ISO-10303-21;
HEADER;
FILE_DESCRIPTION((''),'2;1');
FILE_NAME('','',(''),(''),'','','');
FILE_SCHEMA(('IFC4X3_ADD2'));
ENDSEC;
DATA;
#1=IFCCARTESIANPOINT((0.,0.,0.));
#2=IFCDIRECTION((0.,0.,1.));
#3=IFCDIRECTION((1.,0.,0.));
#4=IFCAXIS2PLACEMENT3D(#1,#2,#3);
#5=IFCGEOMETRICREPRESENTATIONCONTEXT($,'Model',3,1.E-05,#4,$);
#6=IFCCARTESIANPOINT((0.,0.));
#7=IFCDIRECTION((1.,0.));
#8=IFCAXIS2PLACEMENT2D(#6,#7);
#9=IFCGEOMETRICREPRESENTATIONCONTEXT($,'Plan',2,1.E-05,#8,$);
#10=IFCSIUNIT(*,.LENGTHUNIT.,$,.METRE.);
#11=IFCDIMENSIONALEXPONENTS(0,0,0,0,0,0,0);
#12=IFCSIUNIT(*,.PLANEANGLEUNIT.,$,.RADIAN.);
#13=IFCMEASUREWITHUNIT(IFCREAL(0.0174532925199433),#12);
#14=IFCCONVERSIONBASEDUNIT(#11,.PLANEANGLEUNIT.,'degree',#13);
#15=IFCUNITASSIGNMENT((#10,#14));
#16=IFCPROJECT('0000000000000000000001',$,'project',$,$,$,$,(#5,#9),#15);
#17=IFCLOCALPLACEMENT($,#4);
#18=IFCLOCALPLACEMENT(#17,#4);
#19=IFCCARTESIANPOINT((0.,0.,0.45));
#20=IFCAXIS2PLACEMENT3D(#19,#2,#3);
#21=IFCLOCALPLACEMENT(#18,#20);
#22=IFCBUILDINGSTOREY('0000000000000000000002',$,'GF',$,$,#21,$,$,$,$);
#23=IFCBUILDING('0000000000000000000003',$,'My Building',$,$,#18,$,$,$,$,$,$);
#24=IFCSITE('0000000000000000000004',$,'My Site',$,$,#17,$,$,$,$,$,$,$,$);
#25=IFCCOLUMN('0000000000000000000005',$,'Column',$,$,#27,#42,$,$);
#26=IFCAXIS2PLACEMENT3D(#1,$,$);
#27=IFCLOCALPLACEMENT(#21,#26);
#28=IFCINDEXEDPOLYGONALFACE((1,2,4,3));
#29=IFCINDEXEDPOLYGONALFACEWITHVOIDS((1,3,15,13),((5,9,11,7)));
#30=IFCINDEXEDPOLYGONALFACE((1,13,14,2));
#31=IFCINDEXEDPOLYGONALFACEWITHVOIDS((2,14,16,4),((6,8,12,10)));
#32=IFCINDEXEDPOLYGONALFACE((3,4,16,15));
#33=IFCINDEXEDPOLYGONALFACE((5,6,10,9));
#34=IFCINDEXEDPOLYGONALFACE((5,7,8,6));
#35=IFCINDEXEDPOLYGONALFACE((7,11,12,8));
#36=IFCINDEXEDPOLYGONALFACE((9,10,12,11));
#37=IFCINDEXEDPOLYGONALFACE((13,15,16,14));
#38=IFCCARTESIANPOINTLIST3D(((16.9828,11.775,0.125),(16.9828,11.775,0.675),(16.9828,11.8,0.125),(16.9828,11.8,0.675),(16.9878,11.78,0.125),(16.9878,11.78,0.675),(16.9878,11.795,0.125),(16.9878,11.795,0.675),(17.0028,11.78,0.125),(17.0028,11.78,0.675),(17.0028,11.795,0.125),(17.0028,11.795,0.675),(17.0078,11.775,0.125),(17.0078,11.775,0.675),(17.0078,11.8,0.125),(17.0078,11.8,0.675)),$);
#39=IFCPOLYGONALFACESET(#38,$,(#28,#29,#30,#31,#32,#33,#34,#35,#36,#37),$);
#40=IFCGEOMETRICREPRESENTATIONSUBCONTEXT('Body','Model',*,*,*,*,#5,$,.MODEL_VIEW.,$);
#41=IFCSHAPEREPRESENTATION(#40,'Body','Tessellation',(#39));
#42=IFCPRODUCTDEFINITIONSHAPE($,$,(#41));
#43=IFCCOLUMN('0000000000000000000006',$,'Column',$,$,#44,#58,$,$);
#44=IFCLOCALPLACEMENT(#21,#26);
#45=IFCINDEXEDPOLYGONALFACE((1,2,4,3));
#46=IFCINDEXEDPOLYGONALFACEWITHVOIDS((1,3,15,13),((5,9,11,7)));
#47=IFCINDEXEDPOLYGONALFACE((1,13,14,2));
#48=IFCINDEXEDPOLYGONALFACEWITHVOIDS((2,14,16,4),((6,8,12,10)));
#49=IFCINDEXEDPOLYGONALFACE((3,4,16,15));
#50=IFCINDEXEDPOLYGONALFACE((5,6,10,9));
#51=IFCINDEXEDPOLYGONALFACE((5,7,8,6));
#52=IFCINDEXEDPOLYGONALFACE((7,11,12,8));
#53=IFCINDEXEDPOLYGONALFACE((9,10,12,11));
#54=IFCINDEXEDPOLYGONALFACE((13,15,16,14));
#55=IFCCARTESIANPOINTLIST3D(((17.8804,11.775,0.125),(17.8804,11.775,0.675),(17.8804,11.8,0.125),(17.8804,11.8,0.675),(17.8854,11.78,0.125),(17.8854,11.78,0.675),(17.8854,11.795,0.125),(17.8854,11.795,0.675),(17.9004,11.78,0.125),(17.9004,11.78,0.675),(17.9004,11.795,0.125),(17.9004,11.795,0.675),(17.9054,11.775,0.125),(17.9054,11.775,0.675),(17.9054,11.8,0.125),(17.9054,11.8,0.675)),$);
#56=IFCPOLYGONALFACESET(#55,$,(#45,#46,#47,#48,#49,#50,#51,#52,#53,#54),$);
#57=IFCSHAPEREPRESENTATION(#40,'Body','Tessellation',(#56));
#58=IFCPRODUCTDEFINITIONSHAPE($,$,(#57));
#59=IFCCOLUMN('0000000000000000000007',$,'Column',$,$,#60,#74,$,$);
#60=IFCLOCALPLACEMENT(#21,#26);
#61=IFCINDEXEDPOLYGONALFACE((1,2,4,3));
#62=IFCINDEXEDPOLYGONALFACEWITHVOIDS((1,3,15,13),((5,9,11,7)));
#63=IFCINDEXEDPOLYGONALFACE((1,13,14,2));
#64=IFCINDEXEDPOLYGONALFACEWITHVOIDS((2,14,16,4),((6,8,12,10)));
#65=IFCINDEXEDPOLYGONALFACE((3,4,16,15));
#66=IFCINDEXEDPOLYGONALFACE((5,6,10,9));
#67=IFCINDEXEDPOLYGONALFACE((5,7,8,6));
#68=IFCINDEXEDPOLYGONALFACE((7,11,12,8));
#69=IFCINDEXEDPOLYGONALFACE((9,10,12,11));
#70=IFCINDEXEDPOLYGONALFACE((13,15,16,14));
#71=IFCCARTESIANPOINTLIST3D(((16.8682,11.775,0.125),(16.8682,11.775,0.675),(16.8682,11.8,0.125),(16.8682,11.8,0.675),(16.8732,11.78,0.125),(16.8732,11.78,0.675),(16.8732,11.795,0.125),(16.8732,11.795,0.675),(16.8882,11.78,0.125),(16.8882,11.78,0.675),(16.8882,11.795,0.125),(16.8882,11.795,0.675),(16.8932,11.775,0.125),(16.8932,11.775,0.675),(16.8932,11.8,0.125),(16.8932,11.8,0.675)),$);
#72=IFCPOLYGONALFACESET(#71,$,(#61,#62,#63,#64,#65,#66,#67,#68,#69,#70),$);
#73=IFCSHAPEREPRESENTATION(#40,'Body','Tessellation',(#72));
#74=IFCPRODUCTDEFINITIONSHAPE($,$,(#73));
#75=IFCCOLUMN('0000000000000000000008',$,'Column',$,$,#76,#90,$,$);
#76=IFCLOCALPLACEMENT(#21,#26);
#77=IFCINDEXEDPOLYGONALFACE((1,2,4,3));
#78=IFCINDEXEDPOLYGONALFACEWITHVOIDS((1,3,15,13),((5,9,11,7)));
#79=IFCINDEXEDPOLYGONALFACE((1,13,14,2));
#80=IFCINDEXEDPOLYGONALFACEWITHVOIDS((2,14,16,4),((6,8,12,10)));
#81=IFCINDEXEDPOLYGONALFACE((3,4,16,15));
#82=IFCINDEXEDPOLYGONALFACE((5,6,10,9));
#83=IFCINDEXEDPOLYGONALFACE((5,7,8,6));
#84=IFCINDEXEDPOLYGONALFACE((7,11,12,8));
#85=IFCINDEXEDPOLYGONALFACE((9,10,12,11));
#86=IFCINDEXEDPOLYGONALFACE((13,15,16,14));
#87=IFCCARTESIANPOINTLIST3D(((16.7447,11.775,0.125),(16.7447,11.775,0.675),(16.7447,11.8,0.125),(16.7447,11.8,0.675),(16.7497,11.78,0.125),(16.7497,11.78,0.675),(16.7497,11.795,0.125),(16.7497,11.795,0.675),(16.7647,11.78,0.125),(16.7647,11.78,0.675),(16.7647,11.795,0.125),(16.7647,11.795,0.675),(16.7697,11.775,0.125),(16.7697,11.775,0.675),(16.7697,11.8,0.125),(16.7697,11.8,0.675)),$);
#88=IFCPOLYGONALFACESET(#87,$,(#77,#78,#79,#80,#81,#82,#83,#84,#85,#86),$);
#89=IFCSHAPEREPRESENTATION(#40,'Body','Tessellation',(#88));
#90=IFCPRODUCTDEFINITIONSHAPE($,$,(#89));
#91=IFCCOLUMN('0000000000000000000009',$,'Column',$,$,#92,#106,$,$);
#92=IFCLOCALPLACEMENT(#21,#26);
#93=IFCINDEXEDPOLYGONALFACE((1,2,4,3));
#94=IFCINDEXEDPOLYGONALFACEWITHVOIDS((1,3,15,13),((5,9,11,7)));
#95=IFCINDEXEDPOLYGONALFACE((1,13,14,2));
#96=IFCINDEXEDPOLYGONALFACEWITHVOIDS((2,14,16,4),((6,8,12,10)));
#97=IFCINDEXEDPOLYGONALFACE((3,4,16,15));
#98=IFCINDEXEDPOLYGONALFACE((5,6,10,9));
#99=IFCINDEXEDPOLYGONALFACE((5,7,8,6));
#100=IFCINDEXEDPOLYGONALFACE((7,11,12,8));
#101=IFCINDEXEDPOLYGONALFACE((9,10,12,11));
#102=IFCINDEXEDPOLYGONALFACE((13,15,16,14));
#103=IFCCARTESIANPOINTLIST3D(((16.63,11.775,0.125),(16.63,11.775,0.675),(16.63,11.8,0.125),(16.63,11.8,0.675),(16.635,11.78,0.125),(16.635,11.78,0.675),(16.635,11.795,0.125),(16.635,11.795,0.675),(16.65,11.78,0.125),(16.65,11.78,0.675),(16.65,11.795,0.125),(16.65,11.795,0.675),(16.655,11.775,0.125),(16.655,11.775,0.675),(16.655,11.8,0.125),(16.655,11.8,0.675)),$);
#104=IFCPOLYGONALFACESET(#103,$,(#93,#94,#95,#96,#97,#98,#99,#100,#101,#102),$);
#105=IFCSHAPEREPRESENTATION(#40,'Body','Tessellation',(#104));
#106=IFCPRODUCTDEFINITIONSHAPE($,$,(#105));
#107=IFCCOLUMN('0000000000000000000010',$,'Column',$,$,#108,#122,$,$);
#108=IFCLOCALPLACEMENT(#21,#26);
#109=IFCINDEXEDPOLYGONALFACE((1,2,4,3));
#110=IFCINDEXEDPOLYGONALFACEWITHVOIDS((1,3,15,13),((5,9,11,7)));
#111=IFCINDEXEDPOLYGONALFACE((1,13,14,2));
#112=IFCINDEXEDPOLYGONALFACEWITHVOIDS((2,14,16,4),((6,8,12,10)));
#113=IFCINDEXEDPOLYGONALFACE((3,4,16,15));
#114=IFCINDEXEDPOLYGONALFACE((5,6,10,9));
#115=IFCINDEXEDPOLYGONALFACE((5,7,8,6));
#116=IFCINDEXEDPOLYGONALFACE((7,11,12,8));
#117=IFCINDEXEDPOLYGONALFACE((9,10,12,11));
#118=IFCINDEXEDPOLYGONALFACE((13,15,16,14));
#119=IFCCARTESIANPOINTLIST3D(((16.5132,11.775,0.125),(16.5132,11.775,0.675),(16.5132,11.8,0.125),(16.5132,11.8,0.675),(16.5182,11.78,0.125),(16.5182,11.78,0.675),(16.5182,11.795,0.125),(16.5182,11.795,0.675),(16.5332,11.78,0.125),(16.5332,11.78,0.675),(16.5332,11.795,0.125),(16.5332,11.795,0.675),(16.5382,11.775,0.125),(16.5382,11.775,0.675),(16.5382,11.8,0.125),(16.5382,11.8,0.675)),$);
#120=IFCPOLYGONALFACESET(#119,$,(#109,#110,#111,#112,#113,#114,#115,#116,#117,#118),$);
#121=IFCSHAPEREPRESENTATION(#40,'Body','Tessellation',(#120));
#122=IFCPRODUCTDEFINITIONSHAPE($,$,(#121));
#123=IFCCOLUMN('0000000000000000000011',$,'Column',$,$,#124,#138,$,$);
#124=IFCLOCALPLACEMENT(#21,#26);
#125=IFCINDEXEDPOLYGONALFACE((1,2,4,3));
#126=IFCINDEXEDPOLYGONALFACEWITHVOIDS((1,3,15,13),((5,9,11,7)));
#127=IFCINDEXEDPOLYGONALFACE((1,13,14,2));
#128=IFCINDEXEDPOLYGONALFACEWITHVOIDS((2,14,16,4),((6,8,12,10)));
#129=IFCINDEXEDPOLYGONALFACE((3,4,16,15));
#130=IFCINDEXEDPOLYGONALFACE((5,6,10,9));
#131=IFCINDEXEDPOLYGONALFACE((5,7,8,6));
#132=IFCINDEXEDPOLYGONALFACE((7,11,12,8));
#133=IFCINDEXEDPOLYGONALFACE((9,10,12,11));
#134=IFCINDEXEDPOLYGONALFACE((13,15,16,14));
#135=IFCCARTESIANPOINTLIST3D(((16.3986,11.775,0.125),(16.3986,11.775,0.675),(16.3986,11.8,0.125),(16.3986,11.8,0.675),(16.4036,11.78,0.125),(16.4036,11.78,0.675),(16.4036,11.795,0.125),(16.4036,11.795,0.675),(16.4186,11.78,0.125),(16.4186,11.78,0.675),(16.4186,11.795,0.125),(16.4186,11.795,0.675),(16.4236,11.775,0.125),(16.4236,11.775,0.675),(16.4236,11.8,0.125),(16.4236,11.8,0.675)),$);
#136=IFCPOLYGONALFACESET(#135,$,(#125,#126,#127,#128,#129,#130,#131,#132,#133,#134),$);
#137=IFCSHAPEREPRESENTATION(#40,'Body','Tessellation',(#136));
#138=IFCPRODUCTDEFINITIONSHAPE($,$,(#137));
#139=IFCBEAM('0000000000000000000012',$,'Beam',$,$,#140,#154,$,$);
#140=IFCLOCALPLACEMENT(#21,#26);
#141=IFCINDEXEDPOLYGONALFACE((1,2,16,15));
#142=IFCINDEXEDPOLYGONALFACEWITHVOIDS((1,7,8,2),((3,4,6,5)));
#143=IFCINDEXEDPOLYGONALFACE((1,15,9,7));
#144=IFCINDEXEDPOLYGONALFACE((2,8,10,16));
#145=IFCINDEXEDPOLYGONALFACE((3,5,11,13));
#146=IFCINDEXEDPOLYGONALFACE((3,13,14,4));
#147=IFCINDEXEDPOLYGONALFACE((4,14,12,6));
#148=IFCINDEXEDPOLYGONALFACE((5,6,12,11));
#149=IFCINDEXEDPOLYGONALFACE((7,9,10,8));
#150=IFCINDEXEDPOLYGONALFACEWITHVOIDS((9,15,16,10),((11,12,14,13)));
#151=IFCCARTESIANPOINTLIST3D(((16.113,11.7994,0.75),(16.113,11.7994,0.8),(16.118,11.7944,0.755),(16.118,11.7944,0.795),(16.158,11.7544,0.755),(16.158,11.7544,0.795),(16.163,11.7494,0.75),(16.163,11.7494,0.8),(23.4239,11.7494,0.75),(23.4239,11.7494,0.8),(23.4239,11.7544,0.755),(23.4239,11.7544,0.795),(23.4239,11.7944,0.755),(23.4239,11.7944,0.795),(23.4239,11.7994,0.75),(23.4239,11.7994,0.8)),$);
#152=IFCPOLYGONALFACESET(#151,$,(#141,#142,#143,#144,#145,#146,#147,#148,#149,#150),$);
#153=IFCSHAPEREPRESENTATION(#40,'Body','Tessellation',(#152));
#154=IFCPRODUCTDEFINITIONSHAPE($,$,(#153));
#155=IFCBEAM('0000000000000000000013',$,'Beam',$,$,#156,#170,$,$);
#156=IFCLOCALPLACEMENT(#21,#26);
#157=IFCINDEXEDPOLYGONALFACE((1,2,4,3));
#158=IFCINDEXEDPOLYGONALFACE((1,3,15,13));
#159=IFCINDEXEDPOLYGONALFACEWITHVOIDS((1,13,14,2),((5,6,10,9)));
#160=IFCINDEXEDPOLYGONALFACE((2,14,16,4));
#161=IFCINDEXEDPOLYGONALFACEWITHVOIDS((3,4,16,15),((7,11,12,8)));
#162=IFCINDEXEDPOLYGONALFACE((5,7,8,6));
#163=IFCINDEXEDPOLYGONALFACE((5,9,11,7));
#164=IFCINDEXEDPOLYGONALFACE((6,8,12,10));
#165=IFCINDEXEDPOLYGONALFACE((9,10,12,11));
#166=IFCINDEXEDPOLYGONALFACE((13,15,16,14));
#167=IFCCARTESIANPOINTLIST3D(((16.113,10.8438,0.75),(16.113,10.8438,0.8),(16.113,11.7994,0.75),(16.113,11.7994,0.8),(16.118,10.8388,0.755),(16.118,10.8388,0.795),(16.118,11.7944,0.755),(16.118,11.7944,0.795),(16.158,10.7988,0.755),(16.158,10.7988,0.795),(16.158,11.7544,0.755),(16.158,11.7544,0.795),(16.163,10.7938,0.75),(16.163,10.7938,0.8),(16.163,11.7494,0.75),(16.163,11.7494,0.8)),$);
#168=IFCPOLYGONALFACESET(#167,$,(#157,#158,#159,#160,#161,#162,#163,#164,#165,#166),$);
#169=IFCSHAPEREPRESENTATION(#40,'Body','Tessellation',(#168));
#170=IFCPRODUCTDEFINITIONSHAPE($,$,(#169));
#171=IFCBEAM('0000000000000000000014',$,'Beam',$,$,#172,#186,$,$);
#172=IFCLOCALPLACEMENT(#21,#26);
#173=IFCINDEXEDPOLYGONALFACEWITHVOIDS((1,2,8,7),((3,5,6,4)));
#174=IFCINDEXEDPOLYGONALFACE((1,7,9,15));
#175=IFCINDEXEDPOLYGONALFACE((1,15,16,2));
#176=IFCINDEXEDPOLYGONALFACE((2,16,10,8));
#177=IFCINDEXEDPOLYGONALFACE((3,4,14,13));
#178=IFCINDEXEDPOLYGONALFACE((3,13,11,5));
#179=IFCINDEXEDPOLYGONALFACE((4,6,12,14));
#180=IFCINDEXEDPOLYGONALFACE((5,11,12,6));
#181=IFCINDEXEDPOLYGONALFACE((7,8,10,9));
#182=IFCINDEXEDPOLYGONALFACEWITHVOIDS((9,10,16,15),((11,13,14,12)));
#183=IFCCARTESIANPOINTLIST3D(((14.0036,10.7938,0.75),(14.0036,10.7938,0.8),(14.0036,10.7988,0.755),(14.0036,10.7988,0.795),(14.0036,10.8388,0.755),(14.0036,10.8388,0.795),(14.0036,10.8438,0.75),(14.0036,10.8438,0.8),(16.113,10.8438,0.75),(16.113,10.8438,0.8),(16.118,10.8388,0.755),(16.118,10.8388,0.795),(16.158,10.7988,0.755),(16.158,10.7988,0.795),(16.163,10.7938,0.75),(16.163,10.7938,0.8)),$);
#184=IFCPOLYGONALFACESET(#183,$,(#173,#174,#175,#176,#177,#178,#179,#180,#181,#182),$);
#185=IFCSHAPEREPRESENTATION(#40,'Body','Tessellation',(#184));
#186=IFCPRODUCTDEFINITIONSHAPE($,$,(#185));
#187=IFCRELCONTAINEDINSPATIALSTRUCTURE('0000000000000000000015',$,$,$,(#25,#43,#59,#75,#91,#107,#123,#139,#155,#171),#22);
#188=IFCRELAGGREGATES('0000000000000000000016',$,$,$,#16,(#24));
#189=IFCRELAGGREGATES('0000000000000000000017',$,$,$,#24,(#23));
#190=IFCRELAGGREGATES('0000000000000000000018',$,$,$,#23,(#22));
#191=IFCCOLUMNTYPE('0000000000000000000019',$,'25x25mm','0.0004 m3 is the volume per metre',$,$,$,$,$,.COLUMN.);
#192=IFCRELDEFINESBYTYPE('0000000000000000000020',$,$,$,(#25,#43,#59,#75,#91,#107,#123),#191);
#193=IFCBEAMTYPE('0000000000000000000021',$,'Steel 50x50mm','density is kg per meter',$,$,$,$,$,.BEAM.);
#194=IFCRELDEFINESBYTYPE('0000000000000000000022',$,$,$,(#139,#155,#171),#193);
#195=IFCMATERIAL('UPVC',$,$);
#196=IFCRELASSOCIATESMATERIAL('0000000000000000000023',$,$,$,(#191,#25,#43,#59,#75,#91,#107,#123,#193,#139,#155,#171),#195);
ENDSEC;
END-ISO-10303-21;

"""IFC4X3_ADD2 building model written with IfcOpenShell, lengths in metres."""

from ifc_helpers import new_model, entity, si_unit, converted_unit, frame, origin_with_axes, origin_2d_with_axis, place, context, subcontext, project, spatial, hollow_rectangle, extrude, clip, halfspace, material, material_profile, profile_set, profile_usage, type_object, element, save


model = new_model("IFC4X3_ADD2")

# Units and contexts
model_context = context("Model", 3, precision=1e-05, world=origin_with_axes())
plan_context = context("Plan", 2, precision=1e-05, world=origin_2d_with_axis())
body_context = subcontext(model_context, "Body", "Model", "MODEL_VIEW")
ifc_project = project(units=[si_unit("LENGTHUNIT", "METRE"), converted_unit("PLANEANGLEUNIT", "degree", entity("IfcReal", 0.0174532925199433), si_unit("PLANEANGLEUNIT", "RADIAN"), dimensions=[0, 0, 0, 0, 0, 0, 0])], contexts=[model_context, plan_context])

# Site, building, storey
site_placement = place(None, origin_with_axes())
site = spatial("IfcSite", under=ifc_project, at=site_placement, Name="My Site")
building_placement = place(site_placement, origin_with_axes())
building = spatial("IfcBuilding", under=site, at=building_placement, Name="My Building")
storey_placement = place(building_placement, frame((0.0, 0.0, 0.45), z_axis=(0.0, 0.0, 1.0), x_axis=(1.0, 0.0, 0.0)))
storey = spatial("IfcBuildingStorey", under=building, at=storey_placement, Name="GF")

# Columns
ifc_material_1 = material(Name="UPVC")
ifc_material_profile_1 = material_profile(ifc_material_1, hollow_rectangle(XDim=0.025, YDim=0.025, WallThickness=0.005))
ifc_profile_set_1 = profile_set([ifc_material_profile_1])
column_type_1 = type_object("IfcColumnType", Name="25x25mm", Description="0.0004 m3 is the volume per metre", PredefinedType="COLUMN", material=ifc_profile_set_1)
ifc_profile_usage_1 = profile_usage(ifc_profile_set_1, cardinal=5)
column_1_placement = place(storey_placement, frame((16.9953, 11.7875, 0.125), z_axis=(0.0, 0.0, 1.0), x_axis=(1.0, 0.0, 0.0)))
element("IfcColumn", 1, at=column_1_placement, inside=storey, type_object=column_type_1, material=ifc_profile_usage_1, Name="Column", context=body_context, shape_type="SweptSolid", body=[
    extrude(hollow_rectangle(XDim=0.025, YDim=0.025, WallThickness=0.005), origin_with_axes(), (0.0, 0.0, 1.0), 0.55),
])
ifc_profile_usage_2 = profile_usage(ifc_profile_set_1, cardinal=5)
column_2_placement = place(storey_placement, frame((17.8929, 11.7875, 0.125), z_axis=(0.0, 0.0, 1.0), x_axis=(1.0, 0.0, 0.0)))
element("IfcColumn", 2, at=column_2_placement, inside=storey, type_object=column_type_1, material=ifc_profile_usage_2, Name="Column", context=body_context, shape_type="SweptSolid", body=[
    extrude(hollow_rectangle(XDim=0.025, YDim=0.025, WallThickness=0.005), origin_with_axes(), (0.0, 0.0, 1.0), 0.55),
])
ifc_profile_usage_3 = profile_usage(ifc_profile_set_1, cardinal=5)
column_3_placement = place(storey_placement, frame((16.8807, 11.7875, 0.125), z_axis=(0.0, 0.0, 1.0), x_axis=(1.0, 0.0, 0.0)))
element("IfcColumn", 3, at=column_3_placement, inside=storey, type_object=column_type_1, material=ifc_profile_usage_3, Name="Column", context=body_context, shape_type="SweptSolid", body=[
    extrude(hollow_rectangle(XDim=0.025, YDim=0.025, WallThickness=0.005), origin_with_axes(), (0.0, 0.0, 1.0), 0.55),
])
ifc_profile_usage_4 = profile_usage(ifc_profile_set_1, cardinal=5)
column_4_placement = place(storey_placement, frame((16.7572, 11.7875, 0.125), z_axis=(0.0, 0.0, 1.0), x_axis=(1.0, 0.0, 0.0)))
element("IfcColumn", 4, at=column_4_placement, inside=storey, type_object=column_type_1, material=ifc_profile_usage_4, Name="Column", context=body_context, shape_type="SweptSolid", body=[
    extrude(hollow_rectangle(XDim=0.025, YDim=0.025, WallThickness=0.005), origin_with_axes(), (0.0, 0.0, 1.0), 0.55),
])
ifc_profile_usage_5 = profile_usage(ifc_profile_set_1, cardinal=5)
column_5_placement = place(storey_placement, frame((16.6425, 11.7875, 0.125), z_axis=(0.0, 0.0, 1.0), x_axis=(1.0, 0.0, 0.0)))
element("IfcColumn", 5, at=column_5_placement, inside=storey, type_object=column_type_1, material=ifc_profile_usage_5, Name="Column", context=body_context, shape_type="SweptSolid", body=[
    extrude(hollow_rectangle(XDim=0.025, YDim=0.025, WallThickness=0.005), origin_with_axes(), (0.0, 0.0, 1.0), 0.55),
])
ifc_profile_usage_6 = profile_usage(ifc_profile_set_1, cardinal=5)
column_6_placement = place(storey_placement, frame((16.5257, 11.7875, 0.125), z_axis=(0.0, 0.0, 1.0), x_axis=(1.0, 0.0, 0.0)))
element("IfcColumn", 6, at=column_6_placement, inside=storey, type_object=column_type_1, material=ifc_profile_usage_6, Name="Column", context=body_context, shape_type="SweptSolid", body=[
    extrude(hollow_rectangle(XDim=0.025, YDim=0.025, WallThickness=0.005), origin_with_axes(), (0.0, 0.0, 1.0), 0.55),
])
ifc_profile_usage_7 = profile_usage(ifc_profile_set_1, cardinal=5)
column_7_placement = place(storey_placement, frame((16.4111, 11.7875, 0.125), z_axis=(0.0, 0.0, 1.0), x_axis=(1.0, 0.0, 0.0)))
element("IfcColumn", 7, at=column_7_placement, inside=storey, type_object=column_type_1, material=ifc_profile_usage_7, Name="Column", context=body_context, shape_type="SweptSolid", body=[
    extrude(hollow_rectangle(XDim=0.025, YDim=0.025, WallThickness=0.005), origin_with_axes(), (0.0, 0.0, 1.0), 0.55),
])

# Beams
ifc_material_profile_2 = material_profile(ifc_material_1, hollow_rectangle(XDim=0.05, YDim=0.05, WallThickness=0.005))
ifc_profile_set_2 = profile_set([ifc_material_profile_2])
ifc_profile_usage_8 = profile_usage(ifc_profile_set_2)
beam_type_1 = type_object("IfcBeamType", Name="Steel 50x50mm", Description="density is kg per meter", PredefinedType="BEAM", material=ifc_profile_set_2)
beam_1_placement = place(storey_placement, frame((16.113, 11.7744, 0.775), z_axis=(1.0, 0.0, 0.0), x_axis=(0.0, 1.0, 0.0)))
element("IfcBeam", 8, at=beam_1_placement, inside=storey, type_object=beam_type_1, material=ifc_profile_usage_8, Name="Beam", context=body_context, shape_type="Clipping", body=[
    clip(extrude(hollow_rectangle(XDim=0.05, YDim=0.05, WallThickness=0.005), origin_with_axes(), (0.0, 0.0, 1.0), 7.3109), halfspace(frame((0.025, -1.225, 0.0), z_axis=(-0.707107, 0.0, -0.707107), x_axis=(0.0, 1.0, 0.0)), False)),
])
ifc_profile_usage_9 = profile_usage(ifc_profile_set_2)
beam_2_placement = place(storey_placement, frame((16.138, 10.7938, 0.775), z_axis=(0.0, 1.0, 0.0), x_axis=(-1.0, 0.0, 0.0)))
element("IfcBeam", 9, at=beam_2_placement, inside=storey, type_object=beam_type_1, material=ifc_profile_usage_9, Name="Beam", context=body_context, shape_type="Clipping", body=[
    clip(clip(extrude(hollow_rectangle(XDim=0.05, YDim=0.05, WallThickness=0.005), origin_with_axes(), (0.0, 0.0, 1.0), 1.0055), halfspace(frame((0.025, -1.225, 1.0055), z_axis=(-0.707107, 0.0, 0.707107), x_axis=(0.0, 1.0, 0.0)), False)), halfspace(frame((-0.025, -1.225, 0.0), z_axis=(0.707107, 0.0, -0.707107), x_axis=(0.0, -1.0, 0.0)), False)),
])
ifc_profile_usage_10 = profile_usage(ifc_profile_set_2)
beam_3_placement = place(storey_placement, frame((16.163, 10.8188, 0.775), z_axis=(-1.0, 0.0, 0.0), x_axis=(0.0, -1.0, 0.0)))
element("IfcBeam", 10, at=beam_3_placement, inside=storey, type_object=beam_type_1, material=ifc_profile_usage_10, Name="Beam", context=body_context, shape_type="Clipping", body=[
    clip(extrude(hollow_rectangle(XDim=0.05, YDim=0.05, WallThickness=0.005), origin_with_axes(), (0.0, 0.0, 1.0), 2.1594), halfspace(frame((0.025, -1.225, 0.0), z_axis=(-0.707107, 0.0, -0.707107), x_axis=(0.0, 1.0, 0.0)), False)),
])

save(model, "model.ifc")
